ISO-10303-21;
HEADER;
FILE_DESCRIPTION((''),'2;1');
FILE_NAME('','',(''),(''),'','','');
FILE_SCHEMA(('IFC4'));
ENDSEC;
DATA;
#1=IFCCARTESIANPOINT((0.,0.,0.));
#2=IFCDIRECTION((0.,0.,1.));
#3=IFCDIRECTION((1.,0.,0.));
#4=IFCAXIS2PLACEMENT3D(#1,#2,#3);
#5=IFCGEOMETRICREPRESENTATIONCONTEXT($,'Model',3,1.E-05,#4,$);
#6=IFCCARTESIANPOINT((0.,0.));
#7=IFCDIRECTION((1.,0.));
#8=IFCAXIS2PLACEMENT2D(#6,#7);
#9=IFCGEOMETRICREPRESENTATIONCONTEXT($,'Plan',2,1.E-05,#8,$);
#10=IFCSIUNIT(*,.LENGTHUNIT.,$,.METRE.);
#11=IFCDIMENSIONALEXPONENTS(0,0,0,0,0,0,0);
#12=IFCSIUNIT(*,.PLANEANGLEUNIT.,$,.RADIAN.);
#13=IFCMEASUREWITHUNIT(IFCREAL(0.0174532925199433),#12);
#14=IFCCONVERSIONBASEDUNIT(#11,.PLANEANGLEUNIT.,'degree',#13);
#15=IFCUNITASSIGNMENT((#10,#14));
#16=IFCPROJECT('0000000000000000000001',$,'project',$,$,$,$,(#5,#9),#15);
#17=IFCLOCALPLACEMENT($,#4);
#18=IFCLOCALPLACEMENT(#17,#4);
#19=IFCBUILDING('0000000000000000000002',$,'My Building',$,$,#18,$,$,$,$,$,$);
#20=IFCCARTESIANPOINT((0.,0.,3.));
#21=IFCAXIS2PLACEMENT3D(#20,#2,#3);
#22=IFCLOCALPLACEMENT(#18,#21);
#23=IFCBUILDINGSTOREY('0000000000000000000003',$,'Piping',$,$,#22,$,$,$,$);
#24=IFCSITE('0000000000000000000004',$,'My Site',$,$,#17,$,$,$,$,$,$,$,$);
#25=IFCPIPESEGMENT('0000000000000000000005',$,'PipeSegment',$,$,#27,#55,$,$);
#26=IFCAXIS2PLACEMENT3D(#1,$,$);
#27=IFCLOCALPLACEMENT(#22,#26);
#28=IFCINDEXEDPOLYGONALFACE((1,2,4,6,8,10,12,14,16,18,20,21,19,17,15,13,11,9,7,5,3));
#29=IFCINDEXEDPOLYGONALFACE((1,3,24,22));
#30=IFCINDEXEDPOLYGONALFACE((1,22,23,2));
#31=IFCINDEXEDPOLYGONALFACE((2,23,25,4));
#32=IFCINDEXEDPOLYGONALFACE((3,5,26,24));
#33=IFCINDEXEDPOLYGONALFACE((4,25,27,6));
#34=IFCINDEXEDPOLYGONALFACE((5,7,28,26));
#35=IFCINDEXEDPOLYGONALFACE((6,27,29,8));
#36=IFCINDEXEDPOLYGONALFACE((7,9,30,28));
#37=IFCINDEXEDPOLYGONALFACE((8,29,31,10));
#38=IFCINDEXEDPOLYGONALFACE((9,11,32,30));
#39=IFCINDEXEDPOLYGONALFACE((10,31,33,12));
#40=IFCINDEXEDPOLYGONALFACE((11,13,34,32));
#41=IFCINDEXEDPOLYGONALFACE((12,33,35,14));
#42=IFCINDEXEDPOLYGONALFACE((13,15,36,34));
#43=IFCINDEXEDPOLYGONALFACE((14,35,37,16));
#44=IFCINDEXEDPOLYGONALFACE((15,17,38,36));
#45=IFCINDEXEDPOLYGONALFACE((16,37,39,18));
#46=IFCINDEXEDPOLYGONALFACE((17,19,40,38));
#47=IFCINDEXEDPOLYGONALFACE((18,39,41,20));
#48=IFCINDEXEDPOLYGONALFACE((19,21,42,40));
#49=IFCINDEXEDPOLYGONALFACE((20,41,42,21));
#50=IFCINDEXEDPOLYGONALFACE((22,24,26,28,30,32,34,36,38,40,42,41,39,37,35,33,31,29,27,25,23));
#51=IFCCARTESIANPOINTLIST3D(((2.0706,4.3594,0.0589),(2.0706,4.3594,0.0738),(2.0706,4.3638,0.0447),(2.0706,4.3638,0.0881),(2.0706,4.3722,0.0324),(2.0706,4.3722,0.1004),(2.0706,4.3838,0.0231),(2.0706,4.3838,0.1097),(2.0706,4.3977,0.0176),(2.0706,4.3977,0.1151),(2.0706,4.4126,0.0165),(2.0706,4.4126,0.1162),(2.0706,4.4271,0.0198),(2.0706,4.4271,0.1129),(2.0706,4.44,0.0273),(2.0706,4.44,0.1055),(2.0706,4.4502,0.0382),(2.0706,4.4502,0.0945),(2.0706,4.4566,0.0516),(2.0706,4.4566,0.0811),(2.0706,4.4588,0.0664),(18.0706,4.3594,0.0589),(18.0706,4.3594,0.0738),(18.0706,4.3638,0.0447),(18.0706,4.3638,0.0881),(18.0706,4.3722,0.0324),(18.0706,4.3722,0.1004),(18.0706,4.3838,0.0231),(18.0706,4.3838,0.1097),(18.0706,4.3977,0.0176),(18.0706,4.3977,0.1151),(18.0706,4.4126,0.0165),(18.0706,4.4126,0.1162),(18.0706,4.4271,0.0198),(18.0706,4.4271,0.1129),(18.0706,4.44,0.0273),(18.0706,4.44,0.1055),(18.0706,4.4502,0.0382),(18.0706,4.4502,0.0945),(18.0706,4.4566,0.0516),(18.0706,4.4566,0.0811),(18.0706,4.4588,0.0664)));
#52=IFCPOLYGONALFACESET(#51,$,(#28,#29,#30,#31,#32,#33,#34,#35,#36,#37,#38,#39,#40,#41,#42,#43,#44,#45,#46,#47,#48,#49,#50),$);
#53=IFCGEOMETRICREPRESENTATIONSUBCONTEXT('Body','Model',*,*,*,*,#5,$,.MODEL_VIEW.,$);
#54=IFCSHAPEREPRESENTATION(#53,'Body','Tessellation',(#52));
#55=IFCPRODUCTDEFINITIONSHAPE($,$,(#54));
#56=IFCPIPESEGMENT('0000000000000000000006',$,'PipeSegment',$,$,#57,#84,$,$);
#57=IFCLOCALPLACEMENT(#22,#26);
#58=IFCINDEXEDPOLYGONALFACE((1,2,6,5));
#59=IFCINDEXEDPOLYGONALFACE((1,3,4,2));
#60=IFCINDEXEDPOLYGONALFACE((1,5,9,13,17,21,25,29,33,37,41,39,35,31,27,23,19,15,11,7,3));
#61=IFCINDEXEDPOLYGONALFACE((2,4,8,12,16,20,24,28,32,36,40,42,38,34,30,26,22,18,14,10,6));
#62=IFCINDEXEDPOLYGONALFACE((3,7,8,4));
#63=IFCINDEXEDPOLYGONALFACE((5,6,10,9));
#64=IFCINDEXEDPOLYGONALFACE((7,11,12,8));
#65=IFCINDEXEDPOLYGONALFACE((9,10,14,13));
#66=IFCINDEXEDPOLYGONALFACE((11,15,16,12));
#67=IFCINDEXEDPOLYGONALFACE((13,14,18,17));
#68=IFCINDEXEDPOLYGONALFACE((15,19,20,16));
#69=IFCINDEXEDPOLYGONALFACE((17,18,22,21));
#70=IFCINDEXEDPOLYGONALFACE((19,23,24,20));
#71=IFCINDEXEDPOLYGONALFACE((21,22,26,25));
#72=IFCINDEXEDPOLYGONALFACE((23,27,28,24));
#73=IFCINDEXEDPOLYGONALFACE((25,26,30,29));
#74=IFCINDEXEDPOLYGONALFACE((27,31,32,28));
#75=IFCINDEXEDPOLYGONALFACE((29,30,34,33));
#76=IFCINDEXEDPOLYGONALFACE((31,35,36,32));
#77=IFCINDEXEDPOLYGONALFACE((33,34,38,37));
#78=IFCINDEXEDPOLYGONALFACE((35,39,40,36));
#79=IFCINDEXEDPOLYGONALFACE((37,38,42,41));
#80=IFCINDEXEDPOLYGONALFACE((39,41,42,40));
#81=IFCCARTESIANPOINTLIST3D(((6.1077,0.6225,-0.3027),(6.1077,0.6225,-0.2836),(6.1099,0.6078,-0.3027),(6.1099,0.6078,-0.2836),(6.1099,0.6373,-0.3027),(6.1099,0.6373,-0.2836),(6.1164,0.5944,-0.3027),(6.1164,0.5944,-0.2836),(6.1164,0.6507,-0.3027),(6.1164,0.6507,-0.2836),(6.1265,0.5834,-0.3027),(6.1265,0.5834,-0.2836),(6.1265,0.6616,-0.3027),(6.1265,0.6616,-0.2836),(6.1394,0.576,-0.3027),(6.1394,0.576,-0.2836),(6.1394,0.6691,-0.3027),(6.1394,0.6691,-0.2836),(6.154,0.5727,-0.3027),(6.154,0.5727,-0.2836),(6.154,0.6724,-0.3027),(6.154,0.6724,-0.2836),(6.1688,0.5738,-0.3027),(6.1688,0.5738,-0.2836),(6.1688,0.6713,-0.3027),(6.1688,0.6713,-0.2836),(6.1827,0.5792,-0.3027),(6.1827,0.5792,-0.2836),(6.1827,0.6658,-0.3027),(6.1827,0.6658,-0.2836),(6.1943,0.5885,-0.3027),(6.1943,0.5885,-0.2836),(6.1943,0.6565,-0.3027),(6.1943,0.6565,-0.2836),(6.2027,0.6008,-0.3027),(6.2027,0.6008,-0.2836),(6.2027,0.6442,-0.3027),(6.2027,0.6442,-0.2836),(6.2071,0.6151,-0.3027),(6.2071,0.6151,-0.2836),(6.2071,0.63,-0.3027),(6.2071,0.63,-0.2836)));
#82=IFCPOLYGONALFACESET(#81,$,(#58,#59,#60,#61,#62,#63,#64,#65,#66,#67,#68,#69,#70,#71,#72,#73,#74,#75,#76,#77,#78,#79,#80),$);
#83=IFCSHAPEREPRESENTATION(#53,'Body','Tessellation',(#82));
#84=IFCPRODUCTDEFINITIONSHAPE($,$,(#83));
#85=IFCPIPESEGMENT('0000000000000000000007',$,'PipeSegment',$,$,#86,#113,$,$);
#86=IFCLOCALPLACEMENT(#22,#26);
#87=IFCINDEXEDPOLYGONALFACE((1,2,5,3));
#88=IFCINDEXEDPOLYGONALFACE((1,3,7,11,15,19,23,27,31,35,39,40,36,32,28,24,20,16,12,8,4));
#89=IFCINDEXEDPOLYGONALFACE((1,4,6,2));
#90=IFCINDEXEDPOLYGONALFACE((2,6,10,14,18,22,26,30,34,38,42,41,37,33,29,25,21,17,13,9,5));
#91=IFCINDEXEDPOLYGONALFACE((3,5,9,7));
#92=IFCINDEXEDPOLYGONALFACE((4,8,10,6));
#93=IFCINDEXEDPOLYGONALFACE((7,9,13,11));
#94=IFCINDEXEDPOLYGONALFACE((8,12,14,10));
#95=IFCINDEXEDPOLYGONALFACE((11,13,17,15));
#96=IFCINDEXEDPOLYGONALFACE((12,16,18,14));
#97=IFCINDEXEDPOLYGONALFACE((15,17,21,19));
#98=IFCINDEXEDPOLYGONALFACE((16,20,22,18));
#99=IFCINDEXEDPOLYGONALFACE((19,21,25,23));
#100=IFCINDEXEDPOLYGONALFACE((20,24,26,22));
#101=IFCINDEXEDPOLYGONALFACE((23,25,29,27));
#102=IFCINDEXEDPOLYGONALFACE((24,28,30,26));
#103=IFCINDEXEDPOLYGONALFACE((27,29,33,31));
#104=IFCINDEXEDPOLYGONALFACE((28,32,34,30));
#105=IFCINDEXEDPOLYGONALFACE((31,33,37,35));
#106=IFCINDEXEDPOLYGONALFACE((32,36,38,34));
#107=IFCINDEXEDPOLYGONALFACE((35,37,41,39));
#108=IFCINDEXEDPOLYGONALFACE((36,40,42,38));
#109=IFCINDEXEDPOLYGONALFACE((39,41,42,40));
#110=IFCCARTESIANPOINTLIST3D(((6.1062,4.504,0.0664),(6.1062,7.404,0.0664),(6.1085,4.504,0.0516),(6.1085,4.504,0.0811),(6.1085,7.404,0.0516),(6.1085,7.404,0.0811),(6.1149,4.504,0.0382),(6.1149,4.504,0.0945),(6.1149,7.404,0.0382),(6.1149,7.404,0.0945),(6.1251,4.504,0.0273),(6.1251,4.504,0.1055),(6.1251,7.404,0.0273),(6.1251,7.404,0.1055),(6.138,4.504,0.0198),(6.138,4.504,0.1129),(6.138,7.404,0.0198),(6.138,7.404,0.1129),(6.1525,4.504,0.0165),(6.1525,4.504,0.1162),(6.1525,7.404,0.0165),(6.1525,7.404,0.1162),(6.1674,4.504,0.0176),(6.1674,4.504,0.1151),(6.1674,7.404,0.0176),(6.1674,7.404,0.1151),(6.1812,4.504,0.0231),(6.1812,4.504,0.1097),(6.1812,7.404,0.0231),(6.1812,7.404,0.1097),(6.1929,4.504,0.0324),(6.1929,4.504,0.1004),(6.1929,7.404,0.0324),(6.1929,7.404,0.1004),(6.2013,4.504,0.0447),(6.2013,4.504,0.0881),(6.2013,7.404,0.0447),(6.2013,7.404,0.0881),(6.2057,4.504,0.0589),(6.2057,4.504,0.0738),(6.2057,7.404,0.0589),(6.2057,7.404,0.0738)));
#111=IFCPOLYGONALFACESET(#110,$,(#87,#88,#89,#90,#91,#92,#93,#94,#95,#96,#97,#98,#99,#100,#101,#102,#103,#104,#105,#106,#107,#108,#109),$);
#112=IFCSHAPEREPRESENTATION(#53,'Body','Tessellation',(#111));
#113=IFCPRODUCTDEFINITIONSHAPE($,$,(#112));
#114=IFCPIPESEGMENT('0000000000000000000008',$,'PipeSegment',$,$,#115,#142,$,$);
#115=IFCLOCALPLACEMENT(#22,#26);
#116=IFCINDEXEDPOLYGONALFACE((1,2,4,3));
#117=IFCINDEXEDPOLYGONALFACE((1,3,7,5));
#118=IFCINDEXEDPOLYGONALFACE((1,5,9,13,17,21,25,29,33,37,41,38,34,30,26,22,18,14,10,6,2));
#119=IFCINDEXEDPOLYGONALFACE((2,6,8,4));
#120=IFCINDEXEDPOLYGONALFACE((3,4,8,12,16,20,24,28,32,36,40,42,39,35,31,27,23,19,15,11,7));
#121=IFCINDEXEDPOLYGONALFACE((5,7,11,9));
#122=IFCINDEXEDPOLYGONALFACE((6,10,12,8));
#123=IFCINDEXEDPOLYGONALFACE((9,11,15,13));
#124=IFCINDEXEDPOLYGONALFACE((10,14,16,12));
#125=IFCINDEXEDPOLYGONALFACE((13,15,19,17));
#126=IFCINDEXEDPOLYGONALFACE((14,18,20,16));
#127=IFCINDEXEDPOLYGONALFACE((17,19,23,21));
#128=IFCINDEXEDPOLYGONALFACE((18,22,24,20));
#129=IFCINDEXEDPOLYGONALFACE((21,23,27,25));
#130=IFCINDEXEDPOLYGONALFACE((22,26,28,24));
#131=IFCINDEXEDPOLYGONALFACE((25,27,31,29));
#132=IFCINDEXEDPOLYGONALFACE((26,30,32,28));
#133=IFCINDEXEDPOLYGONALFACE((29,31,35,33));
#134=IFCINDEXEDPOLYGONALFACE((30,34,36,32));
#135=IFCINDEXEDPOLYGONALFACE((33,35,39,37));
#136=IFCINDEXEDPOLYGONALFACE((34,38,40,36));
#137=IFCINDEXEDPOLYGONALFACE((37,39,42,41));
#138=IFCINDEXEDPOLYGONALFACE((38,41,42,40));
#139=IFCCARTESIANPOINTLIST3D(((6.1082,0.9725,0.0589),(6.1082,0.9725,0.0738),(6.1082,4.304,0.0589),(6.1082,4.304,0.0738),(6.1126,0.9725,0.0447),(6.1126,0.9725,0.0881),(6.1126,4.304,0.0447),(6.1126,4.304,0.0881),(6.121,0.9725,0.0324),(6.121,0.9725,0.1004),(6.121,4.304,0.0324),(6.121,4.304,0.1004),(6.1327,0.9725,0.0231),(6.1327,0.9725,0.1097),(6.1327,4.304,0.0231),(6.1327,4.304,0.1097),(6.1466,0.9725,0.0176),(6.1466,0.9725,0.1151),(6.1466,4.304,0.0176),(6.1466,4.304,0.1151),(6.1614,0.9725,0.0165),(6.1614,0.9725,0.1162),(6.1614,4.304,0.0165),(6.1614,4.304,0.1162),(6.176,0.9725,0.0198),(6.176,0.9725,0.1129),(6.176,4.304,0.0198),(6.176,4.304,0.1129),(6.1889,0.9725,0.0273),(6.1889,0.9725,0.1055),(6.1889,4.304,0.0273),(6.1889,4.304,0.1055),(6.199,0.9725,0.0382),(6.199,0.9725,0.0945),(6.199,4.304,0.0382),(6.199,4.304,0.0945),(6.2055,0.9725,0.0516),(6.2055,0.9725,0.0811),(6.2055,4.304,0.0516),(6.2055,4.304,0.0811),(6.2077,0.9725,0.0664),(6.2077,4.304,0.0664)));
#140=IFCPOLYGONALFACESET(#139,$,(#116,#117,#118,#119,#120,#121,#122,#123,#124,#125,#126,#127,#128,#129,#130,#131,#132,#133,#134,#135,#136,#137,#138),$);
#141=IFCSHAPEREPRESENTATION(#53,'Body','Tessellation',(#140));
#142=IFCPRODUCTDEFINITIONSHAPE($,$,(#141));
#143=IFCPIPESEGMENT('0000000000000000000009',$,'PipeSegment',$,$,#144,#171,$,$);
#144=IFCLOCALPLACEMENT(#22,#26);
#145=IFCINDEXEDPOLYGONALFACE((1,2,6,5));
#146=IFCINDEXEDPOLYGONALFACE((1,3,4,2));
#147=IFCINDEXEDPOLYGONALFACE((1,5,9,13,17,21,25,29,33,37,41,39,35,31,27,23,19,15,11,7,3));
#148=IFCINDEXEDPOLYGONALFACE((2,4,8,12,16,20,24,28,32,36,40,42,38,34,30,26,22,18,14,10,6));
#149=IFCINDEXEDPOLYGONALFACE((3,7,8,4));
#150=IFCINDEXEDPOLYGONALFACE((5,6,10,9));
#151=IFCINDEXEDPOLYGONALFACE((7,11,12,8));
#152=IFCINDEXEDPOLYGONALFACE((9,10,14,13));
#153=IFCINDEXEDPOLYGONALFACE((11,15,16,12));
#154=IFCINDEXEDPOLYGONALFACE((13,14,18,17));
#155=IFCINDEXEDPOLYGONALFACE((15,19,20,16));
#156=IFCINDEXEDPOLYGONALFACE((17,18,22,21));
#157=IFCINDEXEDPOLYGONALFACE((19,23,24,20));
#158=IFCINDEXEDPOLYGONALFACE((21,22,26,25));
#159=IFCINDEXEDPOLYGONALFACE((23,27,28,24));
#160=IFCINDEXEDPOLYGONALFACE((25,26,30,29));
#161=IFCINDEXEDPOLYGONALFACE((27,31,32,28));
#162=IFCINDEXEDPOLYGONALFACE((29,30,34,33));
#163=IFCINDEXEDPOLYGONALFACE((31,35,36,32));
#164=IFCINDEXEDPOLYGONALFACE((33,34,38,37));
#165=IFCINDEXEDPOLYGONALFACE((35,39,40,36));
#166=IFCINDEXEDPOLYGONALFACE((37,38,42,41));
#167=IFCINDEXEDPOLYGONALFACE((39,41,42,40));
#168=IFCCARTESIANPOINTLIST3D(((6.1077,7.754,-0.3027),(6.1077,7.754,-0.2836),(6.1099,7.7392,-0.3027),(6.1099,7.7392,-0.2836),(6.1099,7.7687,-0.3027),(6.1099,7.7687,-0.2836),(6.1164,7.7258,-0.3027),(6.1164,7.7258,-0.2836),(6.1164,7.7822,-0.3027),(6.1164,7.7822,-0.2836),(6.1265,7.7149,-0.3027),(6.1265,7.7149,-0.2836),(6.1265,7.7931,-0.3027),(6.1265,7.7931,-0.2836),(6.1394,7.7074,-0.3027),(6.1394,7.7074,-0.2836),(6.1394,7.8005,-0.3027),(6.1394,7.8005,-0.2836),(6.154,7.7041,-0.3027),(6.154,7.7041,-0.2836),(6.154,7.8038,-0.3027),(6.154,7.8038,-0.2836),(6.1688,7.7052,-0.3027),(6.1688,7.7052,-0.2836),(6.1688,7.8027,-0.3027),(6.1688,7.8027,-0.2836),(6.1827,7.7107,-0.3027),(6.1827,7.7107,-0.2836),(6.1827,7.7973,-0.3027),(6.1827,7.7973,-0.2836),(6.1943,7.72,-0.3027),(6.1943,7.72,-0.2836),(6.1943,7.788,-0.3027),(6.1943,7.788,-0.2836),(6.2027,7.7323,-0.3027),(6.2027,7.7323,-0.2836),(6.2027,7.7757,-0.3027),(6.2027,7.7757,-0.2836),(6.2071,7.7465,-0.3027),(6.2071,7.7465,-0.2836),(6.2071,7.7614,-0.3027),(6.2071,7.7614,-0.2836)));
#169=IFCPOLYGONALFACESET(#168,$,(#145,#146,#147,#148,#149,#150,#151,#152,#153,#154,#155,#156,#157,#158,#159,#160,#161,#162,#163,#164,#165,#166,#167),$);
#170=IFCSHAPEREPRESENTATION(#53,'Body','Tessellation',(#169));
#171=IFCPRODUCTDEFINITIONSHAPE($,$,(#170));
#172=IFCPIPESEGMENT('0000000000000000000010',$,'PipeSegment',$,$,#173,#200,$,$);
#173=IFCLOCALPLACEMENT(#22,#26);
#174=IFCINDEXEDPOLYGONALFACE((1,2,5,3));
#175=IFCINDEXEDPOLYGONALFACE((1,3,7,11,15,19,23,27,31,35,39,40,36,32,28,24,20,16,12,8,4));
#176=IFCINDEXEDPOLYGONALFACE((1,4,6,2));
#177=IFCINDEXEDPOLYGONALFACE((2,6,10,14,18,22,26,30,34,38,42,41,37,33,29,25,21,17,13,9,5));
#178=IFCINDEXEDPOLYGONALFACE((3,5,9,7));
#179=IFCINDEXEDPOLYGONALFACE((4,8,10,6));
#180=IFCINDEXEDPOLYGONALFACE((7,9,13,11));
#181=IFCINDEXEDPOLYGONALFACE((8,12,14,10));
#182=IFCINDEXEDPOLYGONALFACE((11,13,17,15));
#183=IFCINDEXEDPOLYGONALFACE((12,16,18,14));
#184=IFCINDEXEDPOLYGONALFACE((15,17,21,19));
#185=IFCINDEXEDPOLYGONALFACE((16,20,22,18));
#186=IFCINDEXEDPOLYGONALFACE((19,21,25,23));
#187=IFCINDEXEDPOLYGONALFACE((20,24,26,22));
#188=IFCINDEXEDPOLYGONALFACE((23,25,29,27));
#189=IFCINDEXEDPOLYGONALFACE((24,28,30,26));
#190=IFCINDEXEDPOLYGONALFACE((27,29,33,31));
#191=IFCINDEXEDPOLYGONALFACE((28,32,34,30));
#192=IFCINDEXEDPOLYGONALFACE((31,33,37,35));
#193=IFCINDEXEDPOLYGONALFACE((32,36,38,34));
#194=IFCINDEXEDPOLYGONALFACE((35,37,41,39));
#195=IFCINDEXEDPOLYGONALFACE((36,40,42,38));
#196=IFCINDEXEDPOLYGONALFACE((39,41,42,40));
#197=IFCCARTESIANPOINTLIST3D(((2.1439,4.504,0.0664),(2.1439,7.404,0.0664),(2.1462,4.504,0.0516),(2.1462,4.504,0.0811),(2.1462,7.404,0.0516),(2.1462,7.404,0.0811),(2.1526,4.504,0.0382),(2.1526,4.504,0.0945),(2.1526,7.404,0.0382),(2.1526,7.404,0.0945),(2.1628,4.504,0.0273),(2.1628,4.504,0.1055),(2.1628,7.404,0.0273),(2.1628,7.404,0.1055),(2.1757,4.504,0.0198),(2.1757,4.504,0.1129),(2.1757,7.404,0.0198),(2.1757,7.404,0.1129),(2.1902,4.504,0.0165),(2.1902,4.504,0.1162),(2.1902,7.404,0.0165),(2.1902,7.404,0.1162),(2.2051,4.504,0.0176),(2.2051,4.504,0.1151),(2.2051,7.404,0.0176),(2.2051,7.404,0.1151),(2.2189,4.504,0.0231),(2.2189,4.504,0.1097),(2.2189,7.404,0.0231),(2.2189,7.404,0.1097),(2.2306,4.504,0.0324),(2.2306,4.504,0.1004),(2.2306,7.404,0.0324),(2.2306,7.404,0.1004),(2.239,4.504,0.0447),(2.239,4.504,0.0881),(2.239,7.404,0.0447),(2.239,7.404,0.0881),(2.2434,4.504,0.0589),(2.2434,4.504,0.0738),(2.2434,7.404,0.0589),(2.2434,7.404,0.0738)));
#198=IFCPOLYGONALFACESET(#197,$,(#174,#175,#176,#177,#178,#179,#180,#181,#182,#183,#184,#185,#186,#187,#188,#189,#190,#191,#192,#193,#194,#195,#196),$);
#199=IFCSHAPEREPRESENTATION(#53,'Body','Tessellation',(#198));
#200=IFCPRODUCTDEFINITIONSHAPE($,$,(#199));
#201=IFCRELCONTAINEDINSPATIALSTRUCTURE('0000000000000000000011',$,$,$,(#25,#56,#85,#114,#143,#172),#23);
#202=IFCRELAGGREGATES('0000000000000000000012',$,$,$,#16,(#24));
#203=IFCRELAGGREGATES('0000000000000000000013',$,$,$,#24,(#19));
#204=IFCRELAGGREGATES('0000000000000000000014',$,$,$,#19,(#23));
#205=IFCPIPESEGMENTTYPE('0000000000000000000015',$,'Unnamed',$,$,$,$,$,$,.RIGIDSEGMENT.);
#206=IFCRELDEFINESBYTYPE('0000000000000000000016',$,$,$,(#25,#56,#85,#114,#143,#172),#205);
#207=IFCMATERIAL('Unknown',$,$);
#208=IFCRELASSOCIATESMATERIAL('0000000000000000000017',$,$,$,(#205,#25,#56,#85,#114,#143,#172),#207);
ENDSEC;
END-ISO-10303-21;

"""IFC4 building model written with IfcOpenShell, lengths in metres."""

from ifc_helpers import new_model, entity, si_unit, converted_unit, frame, origin_with_axes, origin_2d_with_axis, place, context, subcontext, project, spatial, circle, extrude, material, material_profile, profile_set, profile_usage, type_object, element, save


model = new_model("IFC4")

# Units and contexts
model_context = context("Model", 3, precision=1e-05, world=origin_with_axes())
plan_context = context("Plan", 2, precision=1e-05, world=origin_2d_with_axis())
body_context = subcontext(model_context, "Body", "Model", "MODEL_VIEW")
ifc_project = project(units=[si_unit("LENGTHUNIT", "METRE"), converted_unit("PLANEANGLEUNIT", "degree", entity("IfcReal", 0.0174532925199433), si_unit("PLANEANGLEUNIT", "RADIAN"), dimensions=[0, 0, 0, 0, 0, 0, 0])], contexts=[model_context, plan_context])

# Site, building, storey
site_placement = place(None, origin_with_axes())
site = spatial("IfcSite", under=ifc_project, at=site_placement, Name="My Site")
building_placement = place(site_placement, origin_with_axes())
building = spatial("IfcBuilding", under=site, at=building_placement, Name="My Building")
storey_placement = place(building_placement, frame((0.0, 0.0, 3.0), z_axis=(0.0, 0.0, 1.0), x_axis=(1.0, 0.0, 0.0)))
storey = spatial("IfcBuildingStorey", under=building, at=storey_placement, Name="Piping")

# Pipe segments
ifc_material = material(Name="Unknown")
ifc_material_profile_1 = material_profile(ifc_material, circle(Radius=0.05))
ifc_profile_set_1 = profile_set([ifc_material_profile_1])
ifc_profile_usage_1 = profile_usage(ifc_profile_set_1, cardinal=5)
pipe_segment_type = type_object("IfcPipeSegmentType", Name="Unnamed", PredefinedType="RIGIDSEGMENT", material=ifc_profile_set_1)
pipe_segment_1_placement = place(storey_placement, frame((2.0706, 4.4088, 0.0664), z_axis=(1.0, 0.0, 0.0), x_axis=(0.0, 1.0, 0.0)))
element("IfcPipeSegment", 1, at=pipe_segment_1_placement, inside=storey, type_object=pipe_segment_type, material=ifc_profile_usage_1, Name="PipeSegment", context=body_context, shape_type="SweptSolid", body=[
    extrude(circle(Radius=0.05), origin_with_axes(), (0.0, 0.0, 1.0), 16.0),
])
ifc_profile_usage_2 = profile_usage(ifc_profile_set_1, cardinal=5)
pipe_segment_2_placement = place(storey_placement, frame((6.1577, 0.6225, -0.2836), z_axis=(0.0, 0.0, -1.0), x_axis=(-1.0, 0.0, 0.0)))
element("IfcPipeSegment", 2, at=pipe_segment_2_placement, inside=storey, type_object=pipe_segment_type, material=ifc_profile_usage_2, Name="PipeSegment", context=body_context, shape_type="SweptSolid", body=[
    extrude(circle(Radius=0.05), origin_with_axes(), (0.0, 0.0, 1.0), 0.0191),
])
ifc_profile_usage_3 = profile_usage(ifc_profile_set_1, cardinal=5)
pipe_segment_3_placement = place(storey_placement, frame((6.1562, 4.504, 0.0664), z_axis=(0.0, 1.0, 0.0), x_axis=(-1.0, 0.0, 0.0)))
element("IfcPipeSegment", 3, at=pipe_segment_3_placement, inside=storey, type_object=pipe_segment_type, material=ifc_profile_usage_3, Name="PipeSegment", context=body_context, shape_type="SweptSolid", body=[
    extrude(circle(Radius=0.05), origin_with_axes(), (0.0, 0.0, 1.0), 2.9),
])
ifc_profile_usage_4 = profile_usage(ifc_profile_set_1, cardinal=5)
pipe_segment_4_placement = place(storey_placement, frame((6.1577, 4.304, 0.0664), z_axis=(0.0, -1.0, 0.000002), x_axis=(1.0, 0.0, 0.0)))
element("IfcPipeSegment", 4, at=pipe_segment_4_placement, inside=storey, type_object=pipe_segment_type, material=ifc_profile_usage_4, Name="PipeSegment", context=body_context, shape_type="SweptSolid", body=[
    extrude(circle(Radius=0.05), origin_with_axes(), (0.0, 0.0, 1.0), 3.3315),
])
ifc_profile_usage_5 = profile_usage(ifc_profile_set_1, cardinal=5)
pipe_segment_5_placement = place(storey_placement, frame((6.1577, 7.754, -0.2836), z_axis=(0.0, 0.0, -1.0), x_axis=(-1.0, 0.0, 0.0)))
element("IfcPipeSegment", 5, at=pipe_segment_5_placement, inside=storey, type_object=pipe_segment_type, material=ifc_profile_usage_5, Name="PipeSegment", context=body_context, shape_type="SweptSolid", body=[
    extrude(circle(Radius=0.05), origin_with_axes(), (0.0, 0.0, 1.0), 0.0191),
])
ifc_profile_usage_6 = profile_usage(ifc_profile_set_1, cardinal=5)
pipe_segment_6_placement = place(storey_placement, frame((2.1939, 4.504, 0.0664), z_axis=(0.0, 1.0, 0.0), x_axis=(-1.0, 0.0, 0.0)))
element("IfcPipeSegment", 6, at=pipe_segment_6_placement, inside=storey, type_object=pipe_segment_type, material=ifc_profile_usage_6, Name="PipeSegment", context=body_context, shape_type="SweptSolid", body=[
    extrude(circle(Radius=0.05), origin_with_axes(), (0.0, 0.0, 1.0), 2.9),
])

save(model, "model.ifc")
